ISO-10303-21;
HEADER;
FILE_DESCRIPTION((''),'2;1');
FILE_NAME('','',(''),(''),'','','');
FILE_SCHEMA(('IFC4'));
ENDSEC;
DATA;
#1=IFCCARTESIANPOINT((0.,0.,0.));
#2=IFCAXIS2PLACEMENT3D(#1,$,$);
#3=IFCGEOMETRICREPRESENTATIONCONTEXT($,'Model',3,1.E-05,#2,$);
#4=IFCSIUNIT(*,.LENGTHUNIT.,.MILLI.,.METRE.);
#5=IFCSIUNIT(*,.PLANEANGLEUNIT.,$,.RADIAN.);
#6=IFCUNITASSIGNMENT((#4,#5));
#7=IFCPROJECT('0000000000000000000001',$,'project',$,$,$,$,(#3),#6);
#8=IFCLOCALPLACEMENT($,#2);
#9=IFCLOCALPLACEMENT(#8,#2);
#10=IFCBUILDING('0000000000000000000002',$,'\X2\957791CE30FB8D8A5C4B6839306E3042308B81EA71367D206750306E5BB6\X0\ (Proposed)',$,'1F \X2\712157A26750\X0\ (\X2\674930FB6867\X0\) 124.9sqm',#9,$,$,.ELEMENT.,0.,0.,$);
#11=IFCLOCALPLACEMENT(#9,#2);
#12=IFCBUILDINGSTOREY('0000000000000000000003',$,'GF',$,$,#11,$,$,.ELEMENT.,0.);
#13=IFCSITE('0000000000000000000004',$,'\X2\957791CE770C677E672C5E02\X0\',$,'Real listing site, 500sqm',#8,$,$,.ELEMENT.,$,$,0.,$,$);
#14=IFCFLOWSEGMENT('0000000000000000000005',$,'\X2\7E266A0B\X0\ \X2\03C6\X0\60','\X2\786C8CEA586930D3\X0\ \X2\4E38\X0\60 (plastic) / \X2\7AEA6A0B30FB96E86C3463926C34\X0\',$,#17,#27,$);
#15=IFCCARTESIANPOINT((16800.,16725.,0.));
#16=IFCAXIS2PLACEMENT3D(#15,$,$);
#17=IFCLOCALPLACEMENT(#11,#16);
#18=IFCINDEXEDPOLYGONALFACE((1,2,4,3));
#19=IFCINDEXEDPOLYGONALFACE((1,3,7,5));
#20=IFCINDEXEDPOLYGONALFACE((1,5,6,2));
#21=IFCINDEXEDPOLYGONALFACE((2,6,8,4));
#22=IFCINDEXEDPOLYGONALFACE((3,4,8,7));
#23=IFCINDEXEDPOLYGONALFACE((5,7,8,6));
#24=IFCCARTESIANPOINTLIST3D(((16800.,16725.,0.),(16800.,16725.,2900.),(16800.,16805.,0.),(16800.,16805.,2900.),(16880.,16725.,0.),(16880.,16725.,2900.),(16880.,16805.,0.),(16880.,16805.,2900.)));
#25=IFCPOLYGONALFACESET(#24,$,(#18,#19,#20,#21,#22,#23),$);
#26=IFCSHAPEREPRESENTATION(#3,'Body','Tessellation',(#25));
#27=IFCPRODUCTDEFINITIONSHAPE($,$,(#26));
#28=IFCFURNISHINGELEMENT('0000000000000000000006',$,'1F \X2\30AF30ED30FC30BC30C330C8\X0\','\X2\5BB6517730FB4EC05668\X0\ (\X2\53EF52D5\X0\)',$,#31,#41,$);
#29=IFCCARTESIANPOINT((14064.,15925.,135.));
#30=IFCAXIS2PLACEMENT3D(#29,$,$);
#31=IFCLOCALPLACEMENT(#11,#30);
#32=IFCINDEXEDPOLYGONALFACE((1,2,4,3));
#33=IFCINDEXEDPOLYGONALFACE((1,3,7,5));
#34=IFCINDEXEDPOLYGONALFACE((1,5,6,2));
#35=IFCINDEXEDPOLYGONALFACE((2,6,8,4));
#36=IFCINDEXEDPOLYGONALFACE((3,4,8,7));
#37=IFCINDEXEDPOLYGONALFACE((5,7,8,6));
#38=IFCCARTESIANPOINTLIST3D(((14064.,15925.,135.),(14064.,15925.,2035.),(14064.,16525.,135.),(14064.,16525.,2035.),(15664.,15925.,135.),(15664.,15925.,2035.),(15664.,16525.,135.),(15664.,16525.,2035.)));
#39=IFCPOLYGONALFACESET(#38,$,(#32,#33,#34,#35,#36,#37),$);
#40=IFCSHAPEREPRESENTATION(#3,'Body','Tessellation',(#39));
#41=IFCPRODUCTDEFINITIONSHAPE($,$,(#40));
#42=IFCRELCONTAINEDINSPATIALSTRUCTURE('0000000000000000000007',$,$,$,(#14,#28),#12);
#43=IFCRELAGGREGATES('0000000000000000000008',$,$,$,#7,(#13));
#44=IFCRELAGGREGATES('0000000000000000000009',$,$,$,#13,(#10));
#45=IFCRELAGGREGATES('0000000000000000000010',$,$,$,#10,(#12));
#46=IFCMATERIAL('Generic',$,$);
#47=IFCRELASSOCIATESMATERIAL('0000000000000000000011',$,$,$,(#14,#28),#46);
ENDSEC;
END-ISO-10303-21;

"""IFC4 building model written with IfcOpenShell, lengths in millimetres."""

from ifc_helpers import new_model, si_unit, frame, frame_2d, origin, place, context, project, spatial, rectangle, extrude, material, element, save


model = new_model("IFC4")

# Units and contexts
model_context = context("Model", 3, precision=1e-05, world=origin())
ifc_project = project(units=[si_unit("LENGTHUNIT", "METRE", prefix="MILLI"), si_unit("PLANEANGLEUNIT", "RADIAN")], contexts=[model_context])

# Site, building, storey
site_placement = place(None, origin())
site = spatial("IfcSite", under=ifc_project, at=site_placement, Name="長野県松本市", ObjectType="Real listing site, 500sqm", CompositionType="ELEMENT", RefElevation=0.0)
building_placement = place(site_placement, origin())
building = spatial("IfcBuilding", under=site, at=building_placement, Name="長野・越屋根のある自然素材の家 (Proposed)", ObjectType="1F 無垢材 (杉・桧) 124.9sqm", CompositionType="ELEMENT", ElevationOfRefHeight=0.0, ElevationOfTerrain=0.0)
storey_placement = place(building_placement, origin())
storey = spatial("IfcBuildingStorey", under=building, at=storey_placement, Name="GF", CompositionType="ELEMENT", Elevation=0.0)

# Shared definitions
ifc_material_1 = material(Name="Generic")

# Flow segment
flow_segment_placement = place(storey_placement, frame((16800.0, 16725.0, 0.0)))
element("IfcFlowSegment", 1, at=flow_segment_placement, inside=storey, material=ifc_material_1, Name="縦樋 φ60", Description="硬質塩ビ 丸60 (plastic) / 竪樋・雨水排水", context=model_context, shape_type="SweptSolid", body=[
    extrude(rectangle(XDim=80.0, YDim=80.0, at=frame_2d((40.0, 40.0))), frame((16800.0, 16725.0, 0.0)), (0.0, 0.0, 1.0), 2900.0),
])

# Furnishing element
furnishing_placement = place(storey_placement, frame((14064.0, 15925.0, 135.0)))
element("IfcFurnishingElement", 2, at=furnishing_placement, inside=storey, material=ifc_material_1, Name="1F クローゼット", Description="家具・什器 (可動)", context=model_context, shape_type="SweptSolid", body=[
    extrude(rectangle(XDim=1600.0, YDim=600.0, at=frame_2d((800.0, 300.0))), frame((14064.0, 15925.0, 135.0)), (0.0, 0.0, 1.0), 1900.0),
])

save(model, "model.ifc")
